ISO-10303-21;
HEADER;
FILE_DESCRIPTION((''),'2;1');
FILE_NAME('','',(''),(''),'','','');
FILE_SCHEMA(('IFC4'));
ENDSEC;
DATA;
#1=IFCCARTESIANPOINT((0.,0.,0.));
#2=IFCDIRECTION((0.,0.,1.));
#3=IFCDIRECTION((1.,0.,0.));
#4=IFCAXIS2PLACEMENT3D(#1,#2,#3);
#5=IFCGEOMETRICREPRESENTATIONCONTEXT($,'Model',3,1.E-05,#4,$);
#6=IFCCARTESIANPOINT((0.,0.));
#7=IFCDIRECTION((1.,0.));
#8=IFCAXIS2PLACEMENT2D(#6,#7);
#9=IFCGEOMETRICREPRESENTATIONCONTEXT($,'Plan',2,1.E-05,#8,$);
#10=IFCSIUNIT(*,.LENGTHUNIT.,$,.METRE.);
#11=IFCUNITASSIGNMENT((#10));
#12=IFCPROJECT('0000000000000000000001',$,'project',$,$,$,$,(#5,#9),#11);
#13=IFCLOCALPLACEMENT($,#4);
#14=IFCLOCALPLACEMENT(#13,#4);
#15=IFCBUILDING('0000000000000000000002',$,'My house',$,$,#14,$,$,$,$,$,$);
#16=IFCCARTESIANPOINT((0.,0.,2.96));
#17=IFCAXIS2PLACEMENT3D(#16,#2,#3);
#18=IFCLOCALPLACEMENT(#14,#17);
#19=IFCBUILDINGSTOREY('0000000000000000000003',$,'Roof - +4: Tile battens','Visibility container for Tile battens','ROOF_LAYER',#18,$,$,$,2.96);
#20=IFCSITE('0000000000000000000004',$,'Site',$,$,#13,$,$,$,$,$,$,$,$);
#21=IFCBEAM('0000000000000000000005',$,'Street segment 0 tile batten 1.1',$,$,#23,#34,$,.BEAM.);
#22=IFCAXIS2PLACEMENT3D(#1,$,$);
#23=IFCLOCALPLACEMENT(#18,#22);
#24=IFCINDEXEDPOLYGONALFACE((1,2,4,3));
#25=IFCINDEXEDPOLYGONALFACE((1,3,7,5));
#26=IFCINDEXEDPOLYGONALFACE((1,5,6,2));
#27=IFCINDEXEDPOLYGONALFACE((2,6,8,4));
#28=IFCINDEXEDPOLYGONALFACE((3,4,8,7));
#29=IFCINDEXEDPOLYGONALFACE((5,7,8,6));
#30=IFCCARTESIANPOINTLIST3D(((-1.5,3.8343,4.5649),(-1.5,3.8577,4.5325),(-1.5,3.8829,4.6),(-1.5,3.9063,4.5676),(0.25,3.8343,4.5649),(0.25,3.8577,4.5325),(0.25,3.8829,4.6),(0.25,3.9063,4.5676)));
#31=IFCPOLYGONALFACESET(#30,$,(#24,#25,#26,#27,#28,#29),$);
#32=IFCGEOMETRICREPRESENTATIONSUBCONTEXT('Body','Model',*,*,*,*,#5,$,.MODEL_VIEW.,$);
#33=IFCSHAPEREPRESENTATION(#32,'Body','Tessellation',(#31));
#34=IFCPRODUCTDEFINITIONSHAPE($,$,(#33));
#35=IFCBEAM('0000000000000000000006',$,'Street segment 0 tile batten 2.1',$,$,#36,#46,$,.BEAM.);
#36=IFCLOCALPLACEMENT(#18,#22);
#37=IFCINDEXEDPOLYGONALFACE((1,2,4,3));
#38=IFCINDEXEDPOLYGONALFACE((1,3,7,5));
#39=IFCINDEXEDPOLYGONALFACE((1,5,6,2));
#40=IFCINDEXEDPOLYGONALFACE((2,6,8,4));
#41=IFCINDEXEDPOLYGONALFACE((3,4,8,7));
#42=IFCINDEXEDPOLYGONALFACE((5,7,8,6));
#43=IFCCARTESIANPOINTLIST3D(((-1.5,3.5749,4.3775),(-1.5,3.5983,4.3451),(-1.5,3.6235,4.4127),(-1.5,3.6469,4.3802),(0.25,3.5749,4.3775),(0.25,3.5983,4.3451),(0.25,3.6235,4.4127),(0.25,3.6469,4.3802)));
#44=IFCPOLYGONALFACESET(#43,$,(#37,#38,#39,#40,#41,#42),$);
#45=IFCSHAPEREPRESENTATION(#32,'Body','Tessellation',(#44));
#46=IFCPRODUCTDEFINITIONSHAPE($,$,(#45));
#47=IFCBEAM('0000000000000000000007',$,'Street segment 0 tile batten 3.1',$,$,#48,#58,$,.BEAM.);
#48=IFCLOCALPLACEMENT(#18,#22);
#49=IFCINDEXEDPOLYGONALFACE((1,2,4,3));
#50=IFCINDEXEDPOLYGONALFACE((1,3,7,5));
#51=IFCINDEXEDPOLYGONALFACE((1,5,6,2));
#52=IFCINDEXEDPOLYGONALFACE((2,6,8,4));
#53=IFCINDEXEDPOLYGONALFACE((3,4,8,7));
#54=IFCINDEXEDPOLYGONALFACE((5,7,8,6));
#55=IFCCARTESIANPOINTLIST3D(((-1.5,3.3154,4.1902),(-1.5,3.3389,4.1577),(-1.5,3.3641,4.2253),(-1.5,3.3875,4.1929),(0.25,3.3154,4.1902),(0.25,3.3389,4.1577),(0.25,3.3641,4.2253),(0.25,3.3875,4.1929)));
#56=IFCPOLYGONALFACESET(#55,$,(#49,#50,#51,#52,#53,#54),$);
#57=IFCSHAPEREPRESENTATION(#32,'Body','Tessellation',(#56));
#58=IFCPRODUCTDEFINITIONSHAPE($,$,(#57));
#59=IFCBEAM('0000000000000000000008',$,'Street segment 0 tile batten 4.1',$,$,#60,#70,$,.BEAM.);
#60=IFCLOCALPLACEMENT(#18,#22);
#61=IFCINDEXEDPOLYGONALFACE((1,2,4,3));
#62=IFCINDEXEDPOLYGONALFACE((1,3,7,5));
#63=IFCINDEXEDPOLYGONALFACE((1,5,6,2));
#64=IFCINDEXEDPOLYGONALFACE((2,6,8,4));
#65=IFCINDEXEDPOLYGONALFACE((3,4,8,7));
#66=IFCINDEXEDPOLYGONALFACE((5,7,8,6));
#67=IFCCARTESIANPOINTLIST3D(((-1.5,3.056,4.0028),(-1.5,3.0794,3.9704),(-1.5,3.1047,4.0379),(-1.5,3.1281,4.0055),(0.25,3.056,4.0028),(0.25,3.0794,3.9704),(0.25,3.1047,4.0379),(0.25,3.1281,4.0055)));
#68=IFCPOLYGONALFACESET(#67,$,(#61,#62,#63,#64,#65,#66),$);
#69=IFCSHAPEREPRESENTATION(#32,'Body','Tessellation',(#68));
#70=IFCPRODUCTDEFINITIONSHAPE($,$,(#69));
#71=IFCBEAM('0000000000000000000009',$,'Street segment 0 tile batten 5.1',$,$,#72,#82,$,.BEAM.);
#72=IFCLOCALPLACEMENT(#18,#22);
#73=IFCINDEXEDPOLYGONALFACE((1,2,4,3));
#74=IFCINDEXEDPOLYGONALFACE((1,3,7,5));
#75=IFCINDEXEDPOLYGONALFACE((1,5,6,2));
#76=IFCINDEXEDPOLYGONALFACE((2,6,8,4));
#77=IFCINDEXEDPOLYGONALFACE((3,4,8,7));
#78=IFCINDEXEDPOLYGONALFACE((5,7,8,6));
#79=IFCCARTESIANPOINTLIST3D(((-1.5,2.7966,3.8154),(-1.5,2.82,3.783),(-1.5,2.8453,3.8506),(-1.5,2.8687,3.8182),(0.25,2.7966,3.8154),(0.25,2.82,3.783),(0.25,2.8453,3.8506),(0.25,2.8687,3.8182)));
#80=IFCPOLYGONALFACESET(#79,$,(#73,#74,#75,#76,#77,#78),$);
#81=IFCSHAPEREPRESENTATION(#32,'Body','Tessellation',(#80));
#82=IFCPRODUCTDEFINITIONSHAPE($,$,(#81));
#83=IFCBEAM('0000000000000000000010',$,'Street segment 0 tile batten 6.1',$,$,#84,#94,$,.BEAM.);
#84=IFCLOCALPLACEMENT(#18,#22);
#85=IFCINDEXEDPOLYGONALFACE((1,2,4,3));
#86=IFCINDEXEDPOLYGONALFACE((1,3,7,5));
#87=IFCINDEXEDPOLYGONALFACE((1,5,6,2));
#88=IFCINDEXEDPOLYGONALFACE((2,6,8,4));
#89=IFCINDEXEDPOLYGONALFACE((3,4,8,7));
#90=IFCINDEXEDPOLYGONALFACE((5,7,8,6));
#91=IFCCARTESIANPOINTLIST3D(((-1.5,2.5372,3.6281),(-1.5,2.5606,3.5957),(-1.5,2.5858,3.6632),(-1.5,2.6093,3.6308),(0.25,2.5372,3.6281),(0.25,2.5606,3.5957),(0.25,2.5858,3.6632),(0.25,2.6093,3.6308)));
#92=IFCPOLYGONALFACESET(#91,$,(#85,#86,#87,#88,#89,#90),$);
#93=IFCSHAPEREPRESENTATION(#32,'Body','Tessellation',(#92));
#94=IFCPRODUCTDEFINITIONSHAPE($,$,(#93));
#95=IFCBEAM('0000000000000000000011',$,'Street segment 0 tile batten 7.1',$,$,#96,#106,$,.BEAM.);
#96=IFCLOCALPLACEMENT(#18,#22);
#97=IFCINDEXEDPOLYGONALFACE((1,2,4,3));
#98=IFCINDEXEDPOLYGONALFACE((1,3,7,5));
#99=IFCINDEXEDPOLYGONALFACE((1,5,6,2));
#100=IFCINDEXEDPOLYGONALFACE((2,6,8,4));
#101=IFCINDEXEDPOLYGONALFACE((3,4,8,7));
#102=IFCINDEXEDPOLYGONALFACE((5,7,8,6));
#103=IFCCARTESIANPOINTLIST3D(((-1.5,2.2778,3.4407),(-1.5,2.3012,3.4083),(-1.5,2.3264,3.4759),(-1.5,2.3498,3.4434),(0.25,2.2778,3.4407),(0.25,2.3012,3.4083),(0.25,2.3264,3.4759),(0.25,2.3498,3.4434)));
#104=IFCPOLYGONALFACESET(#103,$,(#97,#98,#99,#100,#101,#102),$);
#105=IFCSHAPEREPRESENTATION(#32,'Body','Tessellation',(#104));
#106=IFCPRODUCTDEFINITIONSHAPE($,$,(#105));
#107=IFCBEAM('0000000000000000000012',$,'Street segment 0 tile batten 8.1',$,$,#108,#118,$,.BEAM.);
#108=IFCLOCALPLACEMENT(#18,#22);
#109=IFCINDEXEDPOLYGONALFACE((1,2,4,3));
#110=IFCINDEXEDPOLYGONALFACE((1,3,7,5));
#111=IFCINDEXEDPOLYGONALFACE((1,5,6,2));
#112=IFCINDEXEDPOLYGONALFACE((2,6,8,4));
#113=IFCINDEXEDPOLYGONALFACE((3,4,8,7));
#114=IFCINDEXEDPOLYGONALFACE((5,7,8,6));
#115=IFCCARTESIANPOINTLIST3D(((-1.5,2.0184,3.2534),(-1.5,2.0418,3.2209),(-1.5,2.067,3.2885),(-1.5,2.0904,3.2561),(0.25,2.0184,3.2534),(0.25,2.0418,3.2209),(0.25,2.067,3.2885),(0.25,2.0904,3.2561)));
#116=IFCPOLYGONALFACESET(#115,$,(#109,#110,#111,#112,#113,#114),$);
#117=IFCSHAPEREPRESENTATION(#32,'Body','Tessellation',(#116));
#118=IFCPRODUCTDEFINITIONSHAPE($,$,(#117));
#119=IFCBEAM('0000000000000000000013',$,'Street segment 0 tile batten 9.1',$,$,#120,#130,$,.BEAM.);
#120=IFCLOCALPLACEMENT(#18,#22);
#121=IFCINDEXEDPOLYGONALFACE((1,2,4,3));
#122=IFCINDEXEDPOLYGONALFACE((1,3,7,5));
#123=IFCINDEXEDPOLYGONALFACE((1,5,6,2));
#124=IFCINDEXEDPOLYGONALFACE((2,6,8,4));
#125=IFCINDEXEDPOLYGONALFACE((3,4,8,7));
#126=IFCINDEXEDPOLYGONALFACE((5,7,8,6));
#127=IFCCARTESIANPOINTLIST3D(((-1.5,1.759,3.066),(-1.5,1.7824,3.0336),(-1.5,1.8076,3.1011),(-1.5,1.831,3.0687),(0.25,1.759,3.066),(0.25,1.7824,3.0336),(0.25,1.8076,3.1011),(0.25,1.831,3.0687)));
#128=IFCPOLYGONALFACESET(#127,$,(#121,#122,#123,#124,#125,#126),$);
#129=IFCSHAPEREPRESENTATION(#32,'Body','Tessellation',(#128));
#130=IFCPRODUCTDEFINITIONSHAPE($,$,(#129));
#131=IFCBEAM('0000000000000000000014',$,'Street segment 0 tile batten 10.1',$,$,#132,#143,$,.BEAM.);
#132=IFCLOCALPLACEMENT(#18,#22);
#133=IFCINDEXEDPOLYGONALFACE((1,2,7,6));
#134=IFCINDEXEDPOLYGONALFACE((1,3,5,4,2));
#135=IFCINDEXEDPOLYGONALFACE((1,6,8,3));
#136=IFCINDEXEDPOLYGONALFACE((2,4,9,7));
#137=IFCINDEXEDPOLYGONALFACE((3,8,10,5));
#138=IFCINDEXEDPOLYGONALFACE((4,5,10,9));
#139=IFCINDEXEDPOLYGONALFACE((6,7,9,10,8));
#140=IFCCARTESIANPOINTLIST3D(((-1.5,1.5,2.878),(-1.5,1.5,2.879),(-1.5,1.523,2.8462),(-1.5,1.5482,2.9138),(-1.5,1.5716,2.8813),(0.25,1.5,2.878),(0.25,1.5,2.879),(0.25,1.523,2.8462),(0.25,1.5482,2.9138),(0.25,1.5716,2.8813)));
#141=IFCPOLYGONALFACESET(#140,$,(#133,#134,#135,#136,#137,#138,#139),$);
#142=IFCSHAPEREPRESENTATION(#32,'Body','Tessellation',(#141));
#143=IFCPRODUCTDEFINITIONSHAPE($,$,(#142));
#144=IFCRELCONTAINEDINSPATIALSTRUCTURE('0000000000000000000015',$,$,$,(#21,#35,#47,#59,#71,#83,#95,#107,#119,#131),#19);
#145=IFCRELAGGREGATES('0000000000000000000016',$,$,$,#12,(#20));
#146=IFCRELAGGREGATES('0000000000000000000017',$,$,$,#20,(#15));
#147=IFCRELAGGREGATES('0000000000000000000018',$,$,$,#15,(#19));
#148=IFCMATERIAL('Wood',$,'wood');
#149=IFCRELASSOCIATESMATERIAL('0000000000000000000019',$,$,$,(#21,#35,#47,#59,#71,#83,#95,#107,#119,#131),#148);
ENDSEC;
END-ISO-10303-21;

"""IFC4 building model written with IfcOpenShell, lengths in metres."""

from ifc_helpers import new_model, si_unit, frame, origin_with_axes, origin_2d_with_axis, place, context, subcontext, project, spatial, rectangle, extrude, clip, halfspace, source, transform, mapped, material, element, save


model = new_model("IFC4")

# Units and contexts
model_context = context("Model", 3, precision=1e-05, world=origin_with_axes())
plan_context = context("Plan", 2, precision=1e-05, world=origin_2d_with_axis())
body_context = subcontext(model_context, "Body", "Model", "MODEL_VIEW")
ifc_project = project(units=[si_unit("LENGTHUNIT", "METRE")], contexts=[model_context, plan_context])

# Site, building, storey
site_placement = place(None, origin_with_axes())
site = spatial("IfcSite", under=ifc_project, at=site_placement, Name="Site")
building_placement = place(site_placement, origin_with_axes())
building = spatial("IfcBuilding", under=site, at=building_placement, Name="My house")
storey_placement = place(building_placement, frame((0.0, 0.0, 2.96), z_axis=(0.0, 0.0, 1.0), x_axis=(1.0, 0.0, 0.0)))
storey = spatial("IfcBuildingStorey", under=building, at=storey_placement, Name="Roof - +4: Tile battens", Description="Visibility container for Tile battens", ObjectType="ROOF_LAYER", Elevation=2.96)

# Beams
ifc_material = material(Name="Wood", Category="wood")
shared_shape_1 = source(origin_with_axes(), body_context, "Body", "Clipping", [
    clip(clip(extrude(rectangle(XDim=0.06, YDim=0.04), frame((0.0, 0.0, 0.0), z_axis=(1.0, 0.0, 0.0), x_axis=(0.0, 1.0, 0.0)), (0.0, 0.0, 1.0), 1.75), halfspace(frame((0.25, -4.3016, -6.1772), z_axis=(0.0, 0.810664, -0.585512), x_axis=(1.0, 0.0, 0.0)), False)), halfspace(frame((0.25, -6.3282, -4.7134), z_axis=(0.0, -0.810664, 0.585512), x_axis=(-1.0, 0.0, 0.0)), False)),
])
beam_1_placement = place(storey_placement, frame((0.25, 3.8703, 4.5663), z_axis=(0.0, -0.585512, 0.810664), x_axis=(1.0, 0.0, 0.0)))
element("IfcBeam", 1, at=beam_1_placement, inside=storey, material=ifc_material, Name="Street segment 0 tile batten 1.1", PredefinedType="BEAM", context=body_context, shape_type="MappedRepresentation", body=[
    mapped(shared_shape_1, transform((0.0, 0.0, 0.0), x_axis=(-1.0, 0.0, 0.0), y_axis=(0.0, 1.0, 0.0), z_axis=(0.0, 0.0, 1.0), scale=1.0)),
])
shared_shape_2 = source(origin_with_axes(), body_context, "Body", "Clipping", [
    clip(clip(extrude(rectangle(XDim=0.06, YDim=0.04), frame((0.0, 0.0, 0.0), z_axis=(1.0, 0.0, 0.0), x_axis=(0.0, 1.0, 0.0)), (0.0, 0.0, 1.0), 1.75), halfspace(frame((0.25, -3.9816, -6.1772), z_axis=(0.0, 0.810664, -0.585512), x_axis=(1.0, 0.0, 0.0)), False)), halfspace(frame((0.25, -6.0082, -4.7134), z_axis=(0.0, -0.810664, 0.585512), x_axis=(-1.0, 0.0, 0.0)), False)),
])
beam_2_placement = place(storey_placement, frame((0.25, 3.6109, 4.3789), z_axis=(0.0, -0.585512, 0.810664), x_axis=(1.0, 0.0, 0.0)))
element("IfcBeam", 2, at=beam_2_placement, inside=storey, material=ifc_material, Name="Street segment 0 tile batten 2.1", PredefinedType="BEAM", context=body_context, shape_type="MappedRepresentation", body=[
    mapped(shared_shape_2, transform((0.0, 0.0, 0.0), x_axis=(-1.0, 0.0, 0.0), y_axis=(0.0, 1.0, 0.0), z_axis=(0.0, 0.0, 1.0), scale=1.0)),
])
shared_shape_3 = source(origin_with_axes(), body_context, "Body", "Clipping", [
    clip(clip(extrude(rectangle(XDim=0.06, YDim=0.04), frame((0.0, 0.0, 0.0), z_axis=(1.0, 0.0, 0.0), x_axis=(0.0, 1.0, 0.0)), (0.0, 0.0, 1.0), 1.75), halfspace(frame((0.25, -3.6616, -6.1772), z_axis=(0.0, 0.810664, -0.585512), x_axis=(1.0, 0.0, 0.0)), False)), halfspace(frame((0.25, -5.6882, -4.7134), z_axis=(0.0, -0.810664, 0.585512), x_axis=(-1.0, 0.0, 0.0)), False)),
])
beam_3_placement = place(storey_placement, frame((0.25, 3.3515, 4.1915), z_axis=(0.0, -0.585512, 0.810664), x_axis=(1.0, 0.0, 0.0)))
element("IfcBeam", 3, at=beam_3_placement, inside=storey, material=ifc_material, Name="Street segment 0 tile batten 3.1", PredefinedType="BEAM", context=body_context, shape_type="MappedRepresentation", body=[
    mapped(shared_shape_3, transform((0.0, 0.0, 0.0), x_axis=(-1.0, 0.0, 0.0), y_axis=(0.0, 1.0, 0.0), z_axis=(0.0, 0.0, 1.0), scale=1.0)),
])
shared_shape_4 = source(origin_with_axes(), body_context, "Body", "Clipping", [
    clip(clip(extrude(rectangle(XDim=0.06, YDim=0.04), frame((0.0, 0.0, 0.0), z_axis=(1.0, 0.0, 0.0), x_axis=(0.0, 1.0, 0.0)), (0.0, 0.0, 1.0), 1.75), halfspace(frame((0.25, -3.3416, -6.1772), z_axis=(0.0, 0.810664, -0.585512), x_axis=(1.0, 0.0, 0.0)), False)), halfspace(frame((0.25, -5.3682, -4.7134), z_axis=(0.0, -0.810664, 0.585512), x_axis=(-1.0, 0.0, 0.0)), False)),
])
beam_4_placement = place(storey_placement, frame((0.25, 3.0921, 4.0042), z_axis=(0.0, -0.585512, 0.810664), x_axis=(1.0, 0.0, 0.0)))
element("IfcBeam", 4, at=beam_4_placement, inside=storey, material=ifc_material, Name="Street segment 0 tile batten 4.1", PredefinedType="BEAM", context=body_context, shape_type="MappedRepresentation", body=[
    mapped(shared_shape_4, transform((0.0, 0.0, 0.0), x_axis=(-1.0, 0.0, 0.0), y_axis=(0.0, 1.0, 0.0), z_axis=(0.0, 0.0, 1.0), scale=1.0)),
])
shared_shape_5 = source(origin_with_axes(), body_context, "Body", "Clipping", [
    clip(clip(extrude(rectangle(XDim=0.06, YDim=0.04), frame((0.0, 0.0, 0.0), z_axis=(1.0, 0.0, 0.0), x_axis=(0.0, 1.0, 0.0)), (0.0, 0.0, 1.0), 1.75), halfspace(frame((0.25, -3.0216, -6.1772), z_axis=(0.0, 0.810664, -0.585512), x_axis=(1.0, 0.0, 0.0)), False)), halfspace(frame((0.25, -5.0482, -4.7134), z_axis=(0.0, -0.810664, 0.585512), x_axis=(-1.0, 0.0, 0.0)), False)),
])
beam_5_placement = place(storey_placement, frame((0.25, 2.8326, 3.8168), z_axis=(0.0, -0.585512, 0.810664), x_axis=(1.0, 0.0, 0.0)))
element("IfcBeam", 5, at=beam_5_placement, inside=storey, material=ifc_material, Name="Street segment 0 tile batten 5.1", PredefinedType="BEAM", context=body_context, shape_type="MappedRepresentation", body=[
    mapped(shared_shape_5, transform((0.0, 0.0, 0.0), x_axis=(-1.0, 0.0, 0.0), y_axis=(0.0, 1.0, 0.0), z_axis=(0.0, 0.0, 1.0), scale=1.0)),
])
shared_shape_6 = source(origin_with_axes(), body_context, "Body", "Clipping", [
    clip(clip(extrude(rectangle(XDim=0.06, YDim=0.04), frame((0.0, 0.0, 0.0), z_axis=(1.0, 0.0, 0.0), x_axis=(0.0, 1.0, 0.0)), (0.0, 0.0, 1.0), 1.75), halfspace(frame((0.25, -2.7016, -6.1772), z_axis=(0.0, 0.810664, -0.585512), x_axis=(1.0, 0.0, 0.0)), False)), halfspace(frame((0.25, -4.7282, -4.7134), z_axis=(0.0, -0.810664, 0.585512), x_axis=(-1.0, 0.0, 0.0)), False)),
])
beam_6_placement = place(storey_placement, frame((0.25, 2.5732, 3.6294), z_axis=(0.0, -0.585512, 0.810664), x_axis=(1.0, 0.0, 0.0)))
element("IfcBeam", 6, at=beam_6_placement, inside=storey, material=ifc_material, Name="Street segment 0 tile batten 6.1", PredefinedType="BEAM", context=body_context, shape_type="MappedRepresentation", body=[
    mapped(shared_shape_6, transform((0.0, 0.0, 0.0), x_axis=(-1.0, 0.0, 0.0), y_axis=(0.0, 1.0, 0.0), z_axis=(0.0, 0.0, 1.0), scale=1.0)),
])
shared_shape_7 = source(origin_with_axes(), body_context, "Body", "Clipping", [
    clip(clip(extrude(rectangle(XDim=0.06, YDim=0.04), frame((0.0, 0.0, 0.0), z_axis=(1.0, 0.0, 0.0), x_axis=(0.0, 1.0, 0.0)), (0.0, 0.0, 1.0), 1.75), halfspace(frame((0.25, -2.3816, -6.1772), z_axis=(0.0, 0.810664, -0.585512), x_axis=(1.0, 0.0, 0.0)), False)), halfspace(frame((0.25, -4.4082, -4.7134), z_axis=(0.0, -0.810664, 0.585512), x_axis=(-1.0, 0.0, 0.0)), False)),
])
beam_7_placement = place(storey_placement, frame((0.25, 2.3138, 3.4421), z_axis=(0.0, -0.585512, 0.810664), x_axis=(1.0, 0.0, 0.0)))
element("IfcBeam", 7, at=beam_7_placement, inside=storey, material=ifc_material, Name="Street segment 0 tile batten 7.1", PredefinedType="BEAM", context=body_context, shape_type="MappedRepresentation", body=[
    mapped(shared_shape_7, transform((0.0, 0.0, 0.0), x_axis=(-1.0, 0.0, 0.0), y_axis=(0.0, 1.0, 0.0), z_axis=(0.0, 0.0, 1.0), scale=1.0)),
])
shared_shape_8 = source(origin_with_axes(), body_context, "Body", "Clipping", [
    clip(clip(extrude(rectangle(XDim=0.06, YDim=0.04), frame((0.0, 0.0, 0.0), z_axis=(1.0, 0.0, 0.0), x_axis=(0.0, 1.0, 0.0)), (0.0, 0.0, 1.0), 1.75), halfspace(frame((0.25, -2.0616, -6.1772), z_axis=(0.0, 0.810664, -0.585512), x_axis=(1.0, 0.0, 0.0)), False)), halfspace(frame((0.25, -4.0882, -4.7134), z_axis=(0.0, -0.810664, 0.585512), x_axis=(-1.0, 0.0, 0.0)), False)),
])
beam_8_placement = place(storey_placement, frame((0.25, 2.0544, 3.2547), z_axis=(0.0, -0.585512, 0.810664), x_axis=(1.0, 0.0, 0.0)))
element("IfcBeam", 8, at=beam_8_placement, inside=storey, material=ifc_material, Name="Street segment 0 tile batten 8.1", PredefinedType="BEAM", context=body_context, shape_type="MappedRepresentation", body=[
    mapped(shared_shape_8, transform((0.0, 0.0, 0.0), x_axis=(-1.0, 0.0, 0.0), y_axis=(0.0, 1.0, 0.0), z_axis=(0.0, 0.0, 1.0), scale=1.0)),
])
shared_shape_9 = source(origin_with_axes(), body_context, "Body", "Clipping", [
    clip(clip(extrude(rectangle(XDim=0.06, YDim=0.04), frame((0.0, 0.0, 0.0), z_axis=(1.0, 0.0, 0.0), x_axis=(0.0, 1.0, 0.0)), (0.0, 0.0, 1.0), 1.75), halfspace(frame((0.25, -1.7416, -6.1772), z_axis=(0.0, 0.810664, -0.585512), x_axis=(1.0, 0.0, 0.0)), False)), halfspace(frame((0.25, -3.7682, -4.7134), z_axis=(0.0, -0.810664, 0.585512), x_axis=(-1.0, 0.0, 0.0)), False)),
])
beam_9_placement = place(storey_placement, frame((0.25, 1.795, 3.0673), z_axis=(0.0, -0.585512, 0.810664), x_axis=(1.0, 0.0, 0.0)))
element("IfcBeam", 9, at=beam_9_placement, inside=storey, material=ifc_material, Name="Street segment 0 tile batten 9.1", PredefinedType="BEAM", context=body_context, shape_type="MappedRepresentation", body=[
    mapped(shared_shape_9, transform((0.0, 0.0, 0.0), x_axis=(-1.0, 0.0, 0.0), y_axis=(0.0, 1.0, 0.0), z_axis=(0.0, 0.0, 1.0), scale=1.0)),
])
shared_shape_10 = source(origin_with_axes(), body_context, "Body", "Clipping", [
    clip(clip(extrude(rectangle(XDim=0.06, YDim=0.04), frame((0.0, 0.0, 0.0), z_axis=(1.0, 0.0, 0.0), x_axis=(0.0, 1.0, 0.0)), (0.0, 0.0, 1.0), 1.75), halfspace(frame((0.25, -1.4216, -6.1772), z_axis=(0.0, 0.810664, -0.585512), x_axis=(1.0, 0.0, 0.0)), False)), halfspace(frame((0.25, -3.4482, -4.7134), z_axis=(0.0, -0.810664, 0.585512), x_axis=(-1.0, 0.0, 0.0)), False)),
])
beam_10_placement = place(storey_placement, frame((0.25, 1.5356, 2.88), z_axis=(0.0, -0.585512, 0.810664), x_axis=(1.0, 0.0, 0.0)))
element("IfcBeam", 10, at=beam_10_placement, inside=storey, material=ifc_material, Name="Street segment 0 tile batten 10.1", PredefinedType="BEAM", context=body_context, shape_type="MappedRepresentation", body=[
    mapped(shared_shape_10, transform((0.0, 0.0, 0.0), x_axis=(-1.0, 0.0, 0.0), y_axis=(0.0, 1.0, 0.0), z_axis=(0.0, 0.0, 1.0), scale=1.0)),
])

save(model, "model.ifc")
